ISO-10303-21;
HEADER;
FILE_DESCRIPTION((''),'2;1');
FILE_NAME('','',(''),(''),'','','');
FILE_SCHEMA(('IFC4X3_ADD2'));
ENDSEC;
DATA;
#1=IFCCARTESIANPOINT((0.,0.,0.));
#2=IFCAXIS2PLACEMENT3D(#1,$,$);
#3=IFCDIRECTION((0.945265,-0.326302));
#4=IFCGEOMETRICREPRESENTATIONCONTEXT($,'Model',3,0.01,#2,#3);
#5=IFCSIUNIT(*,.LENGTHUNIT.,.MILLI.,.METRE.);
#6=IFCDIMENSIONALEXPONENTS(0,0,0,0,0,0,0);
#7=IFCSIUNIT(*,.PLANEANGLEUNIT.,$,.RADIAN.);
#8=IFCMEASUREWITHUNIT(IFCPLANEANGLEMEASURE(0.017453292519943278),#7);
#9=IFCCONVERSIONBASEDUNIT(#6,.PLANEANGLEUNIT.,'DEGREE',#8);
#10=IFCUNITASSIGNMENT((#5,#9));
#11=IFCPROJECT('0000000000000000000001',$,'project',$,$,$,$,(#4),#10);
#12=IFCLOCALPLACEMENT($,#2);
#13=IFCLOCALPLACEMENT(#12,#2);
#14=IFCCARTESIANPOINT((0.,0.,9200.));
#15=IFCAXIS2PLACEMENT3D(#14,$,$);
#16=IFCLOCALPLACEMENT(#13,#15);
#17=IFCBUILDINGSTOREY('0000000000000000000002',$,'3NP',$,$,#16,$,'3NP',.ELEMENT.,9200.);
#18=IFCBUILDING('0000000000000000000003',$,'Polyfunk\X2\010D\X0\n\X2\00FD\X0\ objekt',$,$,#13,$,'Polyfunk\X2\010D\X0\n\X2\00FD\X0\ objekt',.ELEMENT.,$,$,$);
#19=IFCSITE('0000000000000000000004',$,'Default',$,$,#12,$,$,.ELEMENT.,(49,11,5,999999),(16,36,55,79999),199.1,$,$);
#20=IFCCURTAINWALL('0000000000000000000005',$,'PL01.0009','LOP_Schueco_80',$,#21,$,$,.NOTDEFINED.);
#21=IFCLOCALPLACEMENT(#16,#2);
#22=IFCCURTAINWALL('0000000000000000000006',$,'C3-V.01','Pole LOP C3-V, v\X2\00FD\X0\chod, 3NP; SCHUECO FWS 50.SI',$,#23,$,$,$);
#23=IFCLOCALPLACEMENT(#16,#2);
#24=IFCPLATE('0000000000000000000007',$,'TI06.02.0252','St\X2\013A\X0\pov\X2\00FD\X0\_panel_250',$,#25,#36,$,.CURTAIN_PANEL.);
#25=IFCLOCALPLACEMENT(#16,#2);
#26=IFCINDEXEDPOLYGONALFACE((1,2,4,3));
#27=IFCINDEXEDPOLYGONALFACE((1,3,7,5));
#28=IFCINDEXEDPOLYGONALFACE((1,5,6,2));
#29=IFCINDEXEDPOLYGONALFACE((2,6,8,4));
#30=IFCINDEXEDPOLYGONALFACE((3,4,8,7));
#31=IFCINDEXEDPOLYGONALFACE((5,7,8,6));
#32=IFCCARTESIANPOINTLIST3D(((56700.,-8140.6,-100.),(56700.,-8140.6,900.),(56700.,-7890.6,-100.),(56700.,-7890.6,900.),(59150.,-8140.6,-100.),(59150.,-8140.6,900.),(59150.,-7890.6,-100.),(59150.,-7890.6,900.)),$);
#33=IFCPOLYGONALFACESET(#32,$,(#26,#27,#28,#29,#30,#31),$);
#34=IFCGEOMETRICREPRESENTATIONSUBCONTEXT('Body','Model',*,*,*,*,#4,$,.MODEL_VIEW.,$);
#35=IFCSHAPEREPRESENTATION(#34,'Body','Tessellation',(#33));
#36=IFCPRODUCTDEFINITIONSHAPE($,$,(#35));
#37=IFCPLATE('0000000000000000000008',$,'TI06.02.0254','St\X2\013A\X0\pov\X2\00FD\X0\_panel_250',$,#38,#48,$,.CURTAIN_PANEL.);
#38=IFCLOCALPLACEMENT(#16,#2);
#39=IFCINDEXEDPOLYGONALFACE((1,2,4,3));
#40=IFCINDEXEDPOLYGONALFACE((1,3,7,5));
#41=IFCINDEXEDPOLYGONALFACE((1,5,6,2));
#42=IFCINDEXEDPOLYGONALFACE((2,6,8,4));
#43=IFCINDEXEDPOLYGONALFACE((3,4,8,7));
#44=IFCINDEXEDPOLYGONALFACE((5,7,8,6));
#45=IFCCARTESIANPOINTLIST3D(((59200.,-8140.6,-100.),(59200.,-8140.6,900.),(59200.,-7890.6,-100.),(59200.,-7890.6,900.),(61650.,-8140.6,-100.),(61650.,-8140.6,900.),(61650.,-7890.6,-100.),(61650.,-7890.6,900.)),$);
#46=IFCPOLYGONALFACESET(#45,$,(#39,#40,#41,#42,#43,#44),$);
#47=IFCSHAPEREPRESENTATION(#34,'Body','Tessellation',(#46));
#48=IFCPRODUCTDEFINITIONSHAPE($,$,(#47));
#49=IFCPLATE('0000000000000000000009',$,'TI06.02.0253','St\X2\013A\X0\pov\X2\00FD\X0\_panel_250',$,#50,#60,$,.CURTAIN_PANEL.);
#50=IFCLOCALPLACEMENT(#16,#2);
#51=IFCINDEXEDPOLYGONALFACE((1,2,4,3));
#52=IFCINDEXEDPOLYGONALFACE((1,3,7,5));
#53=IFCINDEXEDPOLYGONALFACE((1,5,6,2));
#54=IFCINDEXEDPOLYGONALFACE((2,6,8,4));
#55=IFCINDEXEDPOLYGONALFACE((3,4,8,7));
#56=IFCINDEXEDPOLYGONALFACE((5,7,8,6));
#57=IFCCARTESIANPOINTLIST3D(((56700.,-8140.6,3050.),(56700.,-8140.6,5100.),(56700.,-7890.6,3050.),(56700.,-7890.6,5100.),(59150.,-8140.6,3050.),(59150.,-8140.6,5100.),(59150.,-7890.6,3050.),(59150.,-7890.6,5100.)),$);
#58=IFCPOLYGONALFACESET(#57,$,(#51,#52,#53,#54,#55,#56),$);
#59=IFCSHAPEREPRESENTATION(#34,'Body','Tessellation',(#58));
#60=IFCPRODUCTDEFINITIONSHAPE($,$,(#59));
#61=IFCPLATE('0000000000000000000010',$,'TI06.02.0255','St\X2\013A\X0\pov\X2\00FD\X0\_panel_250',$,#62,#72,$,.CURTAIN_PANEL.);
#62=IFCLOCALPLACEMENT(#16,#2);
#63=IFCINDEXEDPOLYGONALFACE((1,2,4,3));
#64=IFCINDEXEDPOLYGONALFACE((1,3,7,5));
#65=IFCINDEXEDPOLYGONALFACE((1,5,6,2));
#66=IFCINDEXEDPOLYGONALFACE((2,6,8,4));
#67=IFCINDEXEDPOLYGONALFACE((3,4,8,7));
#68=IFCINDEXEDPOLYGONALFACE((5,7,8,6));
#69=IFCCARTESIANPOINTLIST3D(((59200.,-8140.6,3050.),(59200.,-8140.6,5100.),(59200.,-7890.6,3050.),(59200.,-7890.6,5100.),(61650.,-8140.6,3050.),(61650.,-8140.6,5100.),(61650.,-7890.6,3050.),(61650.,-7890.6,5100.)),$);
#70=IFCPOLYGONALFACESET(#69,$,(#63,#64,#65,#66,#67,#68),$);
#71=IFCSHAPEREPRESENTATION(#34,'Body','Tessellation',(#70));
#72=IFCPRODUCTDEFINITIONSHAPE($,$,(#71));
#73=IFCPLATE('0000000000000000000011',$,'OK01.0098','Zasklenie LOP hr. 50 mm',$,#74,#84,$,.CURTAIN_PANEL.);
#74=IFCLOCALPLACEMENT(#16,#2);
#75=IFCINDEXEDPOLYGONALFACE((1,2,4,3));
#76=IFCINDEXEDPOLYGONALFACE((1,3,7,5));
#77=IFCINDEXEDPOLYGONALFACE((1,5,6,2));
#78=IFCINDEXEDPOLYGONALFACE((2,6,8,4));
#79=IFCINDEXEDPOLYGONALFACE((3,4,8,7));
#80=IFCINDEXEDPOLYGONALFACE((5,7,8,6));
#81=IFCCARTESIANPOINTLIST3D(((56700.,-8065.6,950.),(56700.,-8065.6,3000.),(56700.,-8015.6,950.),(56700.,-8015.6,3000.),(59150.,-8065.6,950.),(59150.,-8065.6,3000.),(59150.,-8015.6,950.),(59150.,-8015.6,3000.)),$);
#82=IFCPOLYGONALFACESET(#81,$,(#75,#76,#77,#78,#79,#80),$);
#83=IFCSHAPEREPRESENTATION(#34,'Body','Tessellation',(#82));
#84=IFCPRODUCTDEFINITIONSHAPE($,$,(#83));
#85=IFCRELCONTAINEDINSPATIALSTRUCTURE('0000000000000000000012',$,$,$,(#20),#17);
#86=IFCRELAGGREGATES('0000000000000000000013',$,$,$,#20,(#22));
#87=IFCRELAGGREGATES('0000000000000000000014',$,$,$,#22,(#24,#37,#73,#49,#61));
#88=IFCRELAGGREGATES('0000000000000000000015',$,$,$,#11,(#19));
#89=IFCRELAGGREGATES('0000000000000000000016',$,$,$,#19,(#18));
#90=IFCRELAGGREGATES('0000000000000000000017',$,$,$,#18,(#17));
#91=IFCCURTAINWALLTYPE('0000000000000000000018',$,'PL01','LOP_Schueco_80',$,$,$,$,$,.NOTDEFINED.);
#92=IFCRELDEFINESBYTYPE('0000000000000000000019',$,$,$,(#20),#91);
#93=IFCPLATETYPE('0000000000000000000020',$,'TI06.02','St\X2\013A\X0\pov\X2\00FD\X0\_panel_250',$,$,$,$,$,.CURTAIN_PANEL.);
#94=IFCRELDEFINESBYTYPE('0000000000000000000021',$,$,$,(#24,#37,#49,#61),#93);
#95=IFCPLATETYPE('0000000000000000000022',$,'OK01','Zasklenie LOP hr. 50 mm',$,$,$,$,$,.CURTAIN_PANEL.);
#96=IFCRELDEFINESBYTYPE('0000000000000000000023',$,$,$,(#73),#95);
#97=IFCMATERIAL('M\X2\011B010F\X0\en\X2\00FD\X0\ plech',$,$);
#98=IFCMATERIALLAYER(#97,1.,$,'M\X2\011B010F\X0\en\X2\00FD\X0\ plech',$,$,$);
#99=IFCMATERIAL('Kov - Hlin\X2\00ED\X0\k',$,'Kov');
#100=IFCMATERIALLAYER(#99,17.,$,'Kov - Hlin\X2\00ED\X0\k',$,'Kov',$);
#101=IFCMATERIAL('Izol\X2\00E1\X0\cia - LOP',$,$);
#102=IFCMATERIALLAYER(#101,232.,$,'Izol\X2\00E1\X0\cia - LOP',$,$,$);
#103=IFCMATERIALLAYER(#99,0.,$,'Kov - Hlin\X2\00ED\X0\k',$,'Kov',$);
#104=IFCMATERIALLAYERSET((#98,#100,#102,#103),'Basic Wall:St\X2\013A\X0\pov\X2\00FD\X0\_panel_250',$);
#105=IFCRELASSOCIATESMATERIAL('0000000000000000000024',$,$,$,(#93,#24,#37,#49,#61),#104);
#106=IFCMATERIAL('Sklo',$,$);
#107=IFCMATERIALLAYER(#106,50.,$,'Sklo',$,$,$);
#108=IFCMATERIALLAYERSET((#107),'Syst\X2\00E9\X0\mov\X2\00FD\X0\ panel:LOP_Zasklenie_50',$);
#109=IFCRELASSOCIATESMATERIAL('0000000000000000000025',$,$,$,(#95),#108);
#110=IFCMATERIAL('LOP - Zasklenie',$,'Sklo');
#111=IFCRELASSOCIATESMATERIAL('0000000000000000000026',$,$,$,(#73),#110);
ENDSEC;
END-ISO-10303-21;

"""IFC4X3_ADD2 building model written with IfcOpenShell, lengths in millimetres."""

from ifc_helpers import new_model, entity, si_unit, converted_unit, direction, frame, frame_2d, origin, origin_2d_with_axis, place, context, subcontext, project, spatial, rectangle, extrude, source, transform, mapped, material, layer, layer_set, layer_usage, type_object, type_shapes, element, aggregate, save


model = new_model("IFC4X3_ADD2")

# Units and contexts
model_context = context("Model", 3, precision=0.01, world=origin(), true_north=direction((0.945265, -0.326302)))
body_context = subcontext(model_context, "Body", "Model", "MODEL_VIEW")
ifc_project = project(units=[si_unit("LENGTHUNIT", "METRE", prefix="MILLI"), converted_unit("PLANEANGLEUNIT", "DEGREE", entity("IfcPlaneAngleMeasure", 0.017453292519943278), si_unit("PLANEANGLEUNIT", "RADIAN"), dimensions=[0, 0, 0, 0, 0, 0, 0])], contexts=[model_context])

# Site, building, storey
site_placement = place(None, origin())
site = spatial("IfcSite", under=ifc_project, at=site_placement, Name="Default", CompositionType="ELEMENT", RefLatitude=(49, 11, 5, 999999), RefLongitude=(16, 36, 55, 79999), RefElevation=199.1)
building_placement = place(site_placement, origin())
building = spatial("IfcBuilding", under=site, at=building_placement, Name="Polyfunkčný objekt", LongName="Polyfunkčný objekt", CompositionType="ELEMENT")
storey_placement = place(building_placement, frame((0.0, 0.0, 9200.0)))
storey = spatial("IfcBuildingStorey", under=building, at=storey_placement, Name="3NP", LongName="3NP", CompositionType="ELEMENT", Elevation=9200.0)

# Curtain walls, plates
curtain_wall_type = type_object("IfcCurtainWallType", Name="PL01", Description="LOP_Schueco_80", PredefinedType="NOTDEFINED")
curtain_wall_1_placement = place(storey_placement, frame((0.0, 0.0, -9200.0)))
curtain_wall_1 = element("IfcCurtainWall", 1, at=curtain_wall_1_placement, inside=storey, type_object=curtain_wall_type, Name="PL01.0009", Description="LOP_Schueco_80", PredefinedType="NOTDEFINED")
curtain_wall_2 = element("IfcCurtainWall", 2, Name="C3-V.01", Description="Pole LOP C3-V, východ, 3NP; SCHUECO FWS 50.SI")
aggregate(curtain_wall_1, [curtain_wall_2])
ifc_material_1 = material(Name="Měďený plech")
ifc_layer_1 = layer(ifc_material_1, 1.0, Name="Měďený plech")
ifc_material_2 = material(Name="Kov - Hliník", Category="Kov")
ifc_layer_2 = layer(ifc_material_2, 17.0, Name="Kov - Hliník", Category="Kov")
ifc_material_3 = material(Name="Izolácia - LOP")
ifc_layer_3 = layer(ifc_material_3, 232.0, Name="Izolácia - LOP")
ifc_layer_4 = layer(ifc_material_2, 0.0, Name="Kov - Hliník", Category="Kov")
ifc_layer_set_1 = layer_set([ifc_layer_1, ifc_layer_2, ifc_layer_3, ifc_layer_4], Name="Basic Wall:Stĺpový_panel_250")
ifc_layer_usage_1 = layer_usage(ifc_layer_set_1, "AXIS2", "POSITIVE", -125.0)
plate_type_1 = type_object("IfcPlateType", Name="TI06.02", Description="Stĺpový_panel_250", PredefinedType="CURTAIN_PANEL", material=ifc_layer_set_1)
plate_1_placement = place(storey_placement, frame((56700.0, -8015.6, -100.0)))
plate_1 = element("IfcPlate", 3, at=plate_1_placement, type_object=plate_type_1, material=ifc_layer_usage_1, Name="TI06.02.0252", Description="Stĺpový_panel_250", PredefinedType="CURTAIN_PANEL", context=body_context, shape_type="SweptSolid", body=[
    extrude(rectangle(XDim=250.0, YDim=2450.0, at=frame_2d((0.0, 0.0), x_axis=(1.0, 0.0))), frame((1225.0, 0.0, 0.0), z_axis=(0.0, 0.0, 1.0), x_axis=(0.0, 1.0, 0.0)), (0.0, 0.0, 1.0), 1000.0),
])
ifc_layer_usage_2 = layer_usage(ifc_layer_set_1, "AXIS2", "POSITIVE", -125.0)
plate_2_placement = place(storey_placement, frame((59200.0, -8015.6, -100.0)))
plate_2 = element("IfcPlate", 4, at=plate_2_placement, type_object=plate_type_1, material=ifc_layer_usage_2, Name="TI06.02.0254", Description="Stĺpový_panel_250", PredefinedType="CURTAIN_PANEL", context=body_context, shape_type="SweptSolid", body=[
    extrude(rectangle(XDim=250.0, YDim=2450.0, at=frame_2d((0.0, 0.0), x_axis=(1.0, 0.0))), frame((1225.0, 0.0, 0.0), z_axis=(0.0, 0.0, 1.0), x_axis=(0.0, 1.0, 0.0)), (0.0, 0.0, 1.0), 1000.0),
])
ifc_layer_usage_3 = layer_usage(ifc_layer_set_1, "AXIS2", "POSITIVE", -125.0)
plate_3_placement = place(storey_placement, frame((56700.0, -8015.6, 3050.0)))
plate_3 = element("IfcPlate", 5, at=plate_3_placement, type_object=plate_type_1, material=ifc_layer_usage_3, Name="TI06.02.0253", Description="Stĺpový_panel_250", PredefinedType="CURTAIN_PANEL", context=body_context, shape_type="SweptSolid", body=[
    extrude(rectangle(XDim=250.0, YDim=2450.0, at=frame_2d((0.0, 0.0), x_axis=(1.0, 0.0))), frame((1225.0, 0.0, 0.0), z_axis=(0.0, 0.0, 1.0), x_axis=(0.0, 1.0, 0.0)), (0.0, 0.0, 1.0), 2050.0),
])
ifc_layer_usage_4 = layer_usage(ifc_layer_set_1, "AXIS2", "POSITIVE", -125.0)
plate_4_placement = place(storey_placement, frame((59200.0, -8015.6, 3050.0)))
plate_4 = element("IfcPlate", 6, at=plate_4_placement, type_object=plate_type_1, material=ifc_layer_usage_4, Name="TI06.02.0255", Description="Stĺpový_panel_250", PredefinedType="CURTAIN_PANEL", context=body_context, shape_type="SweptSolid", body=[
    extrude(rectangle(XDim=250.0, YDim=2450.0, at=frame_2d((0.0, 0.0), x_axis=(1.0, 0.0))), frame((1225.0, 0.0, 0.0), z_axis=(0.0, 0.0, 1.0), x_axis=(0.0, 1.0, 0.0)), (0.0, 0.0, 1.0), 2050.0),
])
ifc_material_4 = material(Name="LOP - Zasklenie", Category="Sklo")
ifc_material_5 = material(Name="Sklo")
ifc_layer_5 = layer(ifc_material_5, 50.0, Name="Sklo")
ifc_layer_set_2 = layer_set([ifc_layer_5], Name="Systémový panel:LOP_Zasklenie_50")
plate_type_2 = type_object("IfcPlateType", Name="OK01", Description="Zasklenie LOP hr. 50 mm", PredefinedType="CURTAIN_PANEL", material=ifc_layer_set_2)
shared_shape_1 = source(origin(), body_context, "Body", "SweptSolid", [
    extrude(rectangle(XDim=50.0, YDim=2450.0, at=origin_2d_with_axis()), frame((0.0, -25.0, 0.0), z_axis=(0.0, 0.0, 1.0), x_axis=(0.0, 1.0, 0.0)), (0.0, 0.0, 1.0), 2050.0),
])
type_shapes(plate_type_2, [shared_shape_1])
plate_5_placement = place(curtain_wall_1_placement, frame((57925.0, -8015.6, 10150.0)))
plate_5 = element("IfcPlate", 7, at=plate_5_placement, type_object=plate_type_2, material=ifc_material_4, Name="OK01.0098", Description="Zasklenie LOP hr. 50 mm", PredefinedType="CURTAIN_PANEL", context=body_context, shape_type="MappedRepresentation", body=[
    mapped(shared_shape_1, transform((0.0, 0.0, 0.0), scale=1.0)),
])
aggregate(curtain_wall_2, [plate_1, plate_2, plate_5, plate_3, plate_4])

save(model, "model.ifc")
